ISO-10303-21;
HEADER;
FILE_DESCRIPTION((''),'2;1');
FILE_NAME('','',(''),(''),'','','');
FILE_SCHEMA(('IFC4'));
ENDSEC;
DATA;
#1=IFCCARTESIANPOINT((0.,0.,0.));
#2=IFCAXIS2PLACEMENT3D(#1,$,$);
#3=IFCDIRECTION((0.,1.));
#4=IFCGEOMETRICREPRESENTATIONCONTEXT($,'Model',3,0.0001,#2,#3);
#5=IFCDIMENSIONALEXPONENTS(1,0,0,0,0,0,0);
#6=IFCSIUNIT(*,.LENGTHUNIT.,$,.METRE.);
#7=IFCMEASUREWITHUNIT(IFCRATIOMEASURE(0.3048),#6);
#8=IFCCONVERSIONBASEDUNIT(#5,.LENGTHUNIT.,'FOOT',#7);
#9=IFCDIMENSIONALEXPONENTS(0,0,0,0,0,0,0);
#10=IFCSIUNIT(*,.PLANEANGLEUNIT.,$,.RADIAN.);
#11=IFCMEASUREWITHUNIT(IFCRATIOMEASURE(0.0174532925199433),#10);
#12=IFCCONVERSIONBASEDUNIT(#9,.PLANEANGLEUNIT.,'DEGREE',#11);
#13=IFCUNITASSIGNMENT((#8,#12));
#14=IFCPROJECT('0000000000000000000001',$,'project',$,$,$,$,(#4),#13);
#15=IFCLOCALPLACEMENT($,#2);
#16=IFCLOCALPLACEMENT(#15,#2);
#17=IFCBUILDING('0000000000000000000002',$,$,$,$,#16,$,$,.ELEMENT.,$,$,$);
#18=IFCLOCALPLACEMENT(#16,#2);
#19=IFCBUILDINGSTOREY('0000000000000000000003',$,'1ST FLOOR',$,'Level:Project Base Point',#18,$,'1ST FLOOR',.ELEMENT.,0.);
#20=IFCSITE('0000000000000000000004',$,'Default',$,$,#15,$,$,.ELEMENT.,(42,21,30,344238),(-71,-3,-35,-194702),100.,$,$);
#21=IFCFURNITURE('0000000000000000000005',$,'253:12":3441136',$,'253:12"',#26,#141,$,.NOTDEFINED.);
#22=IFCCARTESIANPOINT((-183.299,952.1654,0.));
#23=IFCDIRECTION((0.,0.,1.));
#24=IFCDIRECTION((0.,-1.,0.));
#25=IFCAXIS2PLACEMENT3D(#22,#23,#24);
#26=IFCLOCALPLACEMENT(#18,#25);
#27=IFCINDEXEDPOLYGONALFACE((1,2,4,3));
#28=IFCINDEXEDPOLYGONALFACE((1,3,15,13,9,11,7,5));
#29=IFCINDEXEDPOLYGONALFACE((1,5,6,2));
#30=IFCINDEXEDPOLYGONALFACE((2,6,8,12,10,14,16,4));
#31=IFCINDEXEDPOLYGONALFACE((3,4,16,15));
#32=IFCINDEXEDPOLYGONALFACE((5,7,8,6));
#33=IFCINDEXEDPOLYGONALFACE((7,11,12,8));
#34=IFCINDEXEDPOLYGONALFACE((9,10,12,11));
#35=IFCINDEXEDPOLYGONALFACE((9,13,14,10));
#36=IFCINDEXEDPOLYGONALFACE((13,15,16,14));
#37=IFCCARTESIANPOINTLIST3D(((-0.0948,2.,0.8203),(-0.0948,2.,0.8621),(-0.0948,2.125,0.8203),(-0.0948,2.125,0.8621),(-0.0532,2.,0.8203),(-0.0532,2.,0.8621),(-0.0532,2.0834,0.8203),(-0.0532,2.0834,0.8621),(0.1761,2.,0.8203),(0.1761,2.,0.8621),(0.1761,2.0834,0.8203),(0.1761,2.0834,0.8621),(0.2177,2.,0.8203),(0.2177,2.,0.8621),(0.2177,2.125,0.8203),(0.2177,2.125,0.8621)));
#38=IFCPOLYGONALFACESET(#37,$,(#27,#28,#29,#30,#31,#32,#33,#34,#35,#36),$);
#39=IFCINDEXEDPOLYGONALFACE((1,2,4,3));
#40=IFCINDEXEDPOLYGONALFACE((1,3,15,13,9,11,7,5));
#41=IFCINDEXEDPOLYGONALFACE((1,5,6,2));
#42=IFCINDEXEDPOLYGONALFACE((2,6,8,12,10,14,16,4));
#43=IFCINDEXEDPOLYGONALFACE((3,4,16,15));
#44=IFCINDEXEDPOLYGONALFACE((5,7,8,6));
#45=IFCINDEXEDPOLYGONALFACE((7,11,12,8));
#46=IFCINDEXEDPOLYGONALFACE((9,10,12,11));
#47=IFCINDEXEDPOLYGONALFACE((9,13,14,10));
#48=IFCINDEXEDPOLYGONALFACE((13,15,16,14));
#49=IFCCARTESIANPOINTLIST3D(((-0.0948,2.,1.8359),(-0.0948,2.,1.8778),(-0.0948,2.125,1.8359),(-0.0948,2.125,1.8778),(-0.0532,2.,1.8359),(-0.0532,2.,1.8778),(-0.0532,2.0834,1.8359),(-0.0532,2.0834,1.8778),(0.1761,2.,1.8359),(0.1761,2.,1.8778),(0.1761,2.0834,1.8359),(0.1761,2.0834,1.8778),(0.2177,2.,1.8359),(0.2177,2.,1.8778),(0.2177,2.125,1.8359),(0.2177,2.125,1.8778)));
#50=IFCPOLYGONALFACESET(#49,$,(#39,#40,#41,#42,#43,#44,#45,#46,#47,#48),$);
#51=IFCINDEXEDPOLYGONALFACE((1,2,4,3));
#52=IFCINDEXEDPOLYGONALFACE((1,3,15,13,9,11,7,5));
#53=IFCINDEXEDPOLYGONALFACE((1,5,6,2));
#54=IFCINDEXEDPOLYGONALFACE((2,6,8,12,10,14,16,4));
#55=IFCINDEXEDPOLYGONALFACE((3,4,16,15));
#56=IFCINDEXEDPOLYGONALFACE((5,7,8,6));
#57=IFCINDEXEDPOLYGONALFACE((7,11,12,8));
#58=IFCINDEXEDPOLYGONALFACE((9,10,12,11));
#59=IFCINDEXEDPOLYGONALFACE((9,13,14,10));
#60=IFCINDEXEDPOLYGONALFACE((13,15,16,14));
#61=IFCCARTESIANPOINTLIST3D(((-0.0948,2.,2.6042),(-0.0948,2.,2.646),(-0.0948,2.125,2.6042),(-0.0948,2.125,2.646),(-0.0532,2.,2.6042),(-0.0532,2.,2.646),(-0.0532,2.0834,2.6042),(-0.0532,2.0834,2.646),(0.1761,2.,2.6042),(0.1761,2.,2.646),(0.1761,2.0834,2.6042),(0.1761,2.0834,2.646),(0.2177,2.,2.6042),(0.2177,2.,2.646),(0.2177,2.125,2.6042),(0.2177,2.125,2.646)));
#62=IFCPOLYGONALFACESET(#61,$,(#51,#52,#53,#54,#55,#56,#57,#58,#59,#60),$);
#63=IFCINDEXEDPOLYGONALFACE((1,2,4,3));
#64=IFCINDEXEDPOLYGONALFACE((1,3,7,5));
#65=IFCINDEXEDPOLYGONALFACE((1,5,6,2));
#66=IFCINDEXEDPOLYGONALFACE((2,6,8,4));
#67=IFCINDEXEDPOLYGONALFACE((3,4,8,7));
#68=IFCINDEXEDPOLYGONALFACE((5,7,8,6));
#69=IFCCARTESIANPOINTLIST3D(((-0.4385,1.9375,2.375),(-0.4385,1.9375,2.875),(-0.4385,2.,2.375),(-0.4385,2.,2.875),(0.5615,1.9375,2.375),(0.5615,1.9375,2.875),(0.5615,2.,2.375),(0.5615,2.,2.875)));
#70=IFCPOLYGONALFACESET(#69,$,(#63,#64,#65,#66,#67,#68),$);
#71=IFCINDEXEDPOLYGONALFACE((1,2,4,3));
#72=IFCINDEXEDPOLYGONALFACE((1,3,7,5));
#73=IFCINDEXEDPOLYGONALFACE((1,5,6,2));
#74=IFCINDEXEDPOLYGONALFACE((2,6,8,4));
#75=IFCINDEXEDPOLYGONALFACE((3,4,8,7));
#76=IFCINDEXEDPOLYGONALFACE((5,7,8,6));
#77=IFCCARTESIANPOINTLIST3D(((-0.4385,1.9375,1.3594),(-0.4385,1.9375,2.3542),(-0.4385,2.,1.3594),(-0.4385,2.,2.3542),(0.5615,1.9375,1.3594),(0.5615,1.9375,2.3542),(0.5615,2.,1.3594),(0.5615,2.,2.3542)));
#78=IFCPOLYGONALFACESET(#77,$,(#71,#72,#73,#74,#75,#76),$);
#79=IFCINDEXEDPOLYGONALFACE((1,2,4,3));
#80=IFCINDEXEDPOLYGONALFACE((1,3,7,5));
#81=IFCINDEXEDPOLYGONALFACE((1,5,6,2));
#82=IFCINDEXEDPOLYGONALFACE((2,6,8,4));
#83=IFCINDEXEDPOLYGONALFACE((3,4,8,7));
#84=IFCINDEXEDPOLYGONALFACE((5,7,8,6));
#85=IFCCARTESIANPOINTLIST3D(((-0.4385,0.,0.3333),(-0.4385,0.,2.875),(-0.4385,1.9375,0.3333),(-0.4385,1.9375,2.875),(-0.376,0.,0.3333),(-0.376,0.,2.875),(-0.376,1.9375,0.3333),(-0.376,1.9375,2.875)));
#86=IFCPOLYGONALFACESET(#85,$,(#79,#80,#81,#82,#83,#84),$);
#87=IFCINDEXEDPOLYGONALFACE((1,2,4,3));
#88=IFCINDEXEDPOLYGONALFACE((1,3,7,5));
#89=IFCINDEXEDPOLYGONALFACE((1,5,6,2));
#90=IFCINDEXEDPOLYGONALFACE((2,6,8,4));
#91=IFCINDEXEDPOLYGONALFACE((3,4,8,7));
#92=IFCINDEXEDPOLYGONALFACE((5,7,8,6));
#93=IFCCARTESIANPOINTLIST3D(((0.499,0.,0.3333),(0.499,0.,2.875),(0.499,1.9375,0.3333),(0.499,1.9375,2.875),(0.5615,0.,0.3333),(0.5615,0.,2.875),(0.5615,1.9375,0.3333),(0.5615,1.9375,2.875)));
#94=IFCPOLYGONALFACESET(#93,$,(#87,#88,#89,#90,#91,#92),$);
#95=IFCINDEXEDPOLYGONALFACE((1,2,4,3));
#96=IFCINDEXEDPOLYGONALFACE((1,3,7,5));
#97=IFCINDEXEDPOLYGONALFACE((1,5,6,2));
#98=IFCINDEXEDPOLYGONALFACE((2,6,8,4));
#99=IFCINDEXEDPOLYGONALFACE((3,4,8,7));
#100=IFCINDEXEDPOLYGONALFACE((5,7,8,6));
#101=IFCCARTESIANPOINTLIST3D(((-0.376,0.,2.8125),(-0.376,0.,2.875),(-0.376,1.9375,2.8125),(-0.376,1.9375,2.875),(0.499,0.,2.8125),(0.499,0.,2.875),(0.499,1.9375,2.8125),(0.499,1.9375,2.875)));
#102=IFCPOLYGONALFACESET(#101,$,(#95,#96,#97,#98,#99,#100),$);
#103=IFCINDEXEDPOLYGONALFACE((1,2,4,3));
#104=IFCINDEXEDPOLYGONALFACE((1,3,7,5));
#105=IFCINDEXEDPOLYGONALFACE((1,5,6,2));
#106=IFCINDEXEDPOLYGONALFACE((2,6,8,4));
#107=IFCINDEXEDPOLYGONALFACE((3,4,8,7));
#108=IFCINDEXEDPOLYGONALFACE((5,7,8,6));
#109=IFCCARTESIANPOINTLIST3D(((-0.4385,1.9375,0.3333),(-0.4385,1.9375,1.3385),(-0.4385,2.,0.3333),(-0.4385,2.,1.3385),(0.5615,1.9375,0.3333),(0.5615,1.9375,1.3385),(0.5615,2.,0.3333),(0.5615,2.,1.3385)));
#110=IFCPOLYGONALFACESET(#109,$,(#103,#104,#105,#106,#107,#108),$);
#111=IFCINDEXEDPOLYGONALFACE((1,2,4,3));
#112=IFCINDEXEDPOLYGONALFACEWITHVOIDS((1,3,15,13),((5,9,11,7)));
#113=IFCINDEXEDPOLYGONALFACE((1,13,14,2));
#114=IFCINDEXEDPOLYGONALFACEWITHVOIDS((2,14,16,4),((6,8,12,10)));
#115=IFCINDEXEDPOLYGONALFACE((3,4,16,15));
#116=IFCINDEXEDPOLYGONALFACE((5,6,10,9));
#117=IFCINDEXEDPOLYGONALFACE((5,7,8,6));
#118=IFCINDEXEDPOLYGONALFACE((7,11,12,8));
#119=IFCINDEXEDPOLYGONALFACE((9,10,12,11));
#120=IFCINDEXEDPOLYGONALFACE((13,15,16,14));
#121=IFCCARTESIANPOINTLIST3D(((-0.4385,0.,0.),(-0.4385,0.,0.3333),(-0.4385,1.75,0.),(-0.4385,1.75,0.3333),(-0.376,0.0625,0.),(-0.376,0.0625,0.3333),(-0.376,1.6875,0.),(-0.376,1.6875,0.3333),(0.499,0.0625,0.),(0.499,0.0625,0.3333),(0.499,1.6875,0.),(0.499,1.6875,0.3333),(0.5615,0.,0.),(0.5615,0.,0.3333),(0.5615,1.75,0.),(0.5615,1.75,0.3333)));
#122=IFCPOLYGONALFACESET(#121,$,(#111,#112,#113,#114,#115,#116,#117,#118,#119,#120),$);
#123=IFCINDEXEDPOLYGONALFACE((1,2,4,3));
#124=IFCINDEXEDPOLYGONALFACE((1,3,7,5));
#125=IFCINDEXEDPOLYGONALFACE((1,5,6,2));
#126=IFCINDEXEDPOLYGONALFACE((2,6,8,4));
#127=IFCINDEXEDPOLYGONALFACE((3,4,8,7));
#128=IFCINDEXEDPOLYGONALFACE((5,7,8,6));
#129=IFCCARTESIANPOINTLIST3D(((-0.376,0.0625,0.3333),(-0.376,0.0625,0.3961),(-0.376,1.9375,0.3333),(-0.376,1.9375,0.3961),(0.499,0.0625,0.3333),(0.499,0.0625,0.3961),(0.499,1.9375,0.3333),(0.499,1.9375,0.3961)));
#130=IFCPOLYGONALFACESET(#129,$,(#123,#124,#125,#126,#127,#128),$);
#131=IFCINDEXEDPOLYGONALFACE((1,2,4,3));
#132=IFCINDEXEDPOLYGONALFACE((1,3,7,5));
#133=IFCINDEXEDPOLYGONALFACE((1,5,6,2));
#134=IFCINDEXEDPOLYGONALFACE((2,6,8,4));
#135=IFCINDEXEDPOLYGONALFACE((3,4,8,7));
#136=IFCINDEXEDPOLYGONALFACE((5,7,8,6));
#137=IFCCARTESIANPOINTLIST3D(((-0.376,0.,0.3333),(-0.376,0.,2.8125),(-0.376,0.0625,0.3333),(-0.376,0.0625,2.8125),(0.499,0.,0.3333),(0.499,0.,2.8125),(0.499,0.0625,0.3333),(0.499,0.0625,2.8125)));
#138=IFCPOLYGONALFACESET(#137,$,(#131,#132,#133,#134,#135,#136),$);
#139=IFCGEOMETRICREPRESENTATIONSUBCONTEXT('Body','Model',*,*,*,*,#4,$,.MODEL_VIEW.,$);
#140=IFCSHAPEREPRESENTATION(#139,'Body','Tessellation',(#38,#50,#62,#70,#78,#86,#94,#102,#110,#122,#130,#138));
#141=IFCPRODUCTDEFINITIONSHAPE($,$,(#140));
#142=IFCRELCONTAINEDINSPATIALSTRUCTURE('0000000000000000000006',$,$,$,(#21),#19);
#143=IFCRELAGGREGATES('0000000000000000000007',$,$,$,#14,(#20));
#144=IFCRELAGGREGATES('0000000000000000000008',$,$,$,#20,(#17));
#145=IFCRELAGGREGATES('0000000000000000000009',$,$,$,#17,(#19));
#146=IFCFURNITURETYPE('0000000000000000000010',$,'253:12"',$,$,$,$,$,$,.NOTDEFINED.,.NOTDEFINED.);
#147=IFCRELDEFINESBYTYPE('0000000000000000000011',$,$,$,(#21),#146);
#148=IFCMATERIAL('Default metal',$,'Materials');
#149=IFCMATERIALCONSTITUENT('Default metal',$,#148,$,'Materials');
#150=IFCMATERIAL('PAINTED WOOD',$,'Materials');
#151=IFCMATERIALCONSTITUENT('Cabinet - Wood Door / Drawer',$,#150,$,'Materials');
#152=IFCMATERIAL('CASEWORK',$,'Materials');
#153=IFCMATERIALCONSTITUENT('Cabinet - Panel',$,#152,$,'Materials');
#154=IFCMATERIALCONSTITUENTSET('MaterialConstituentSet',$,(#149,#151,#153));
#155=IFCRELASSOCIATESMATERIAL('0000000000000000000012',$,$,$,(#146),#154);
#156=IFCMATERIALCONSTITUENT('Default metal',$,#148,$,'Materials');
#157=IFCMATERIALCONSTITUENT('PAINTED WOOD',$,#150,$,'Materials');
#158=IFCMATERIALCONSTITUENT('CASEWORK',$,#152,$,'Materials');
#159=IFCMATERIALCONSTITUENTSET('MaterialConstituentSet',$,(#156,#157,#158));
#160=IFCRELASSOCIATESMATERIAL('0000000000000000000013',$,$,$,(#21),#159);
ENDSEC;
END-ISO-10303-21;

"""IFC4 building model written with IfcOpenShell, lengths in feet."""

from ifc_helpers import new_model, entity, si_unit, converted_unit, direction, frame, frame_2d, origin, origin_2d_with_axis, place, context, subcontext, project, spatial, polyline, rectangle, outline, extrude, source, transform, mapped, material, constituent, constituent_set, type_object, type_shapes, element, save


model = new_model("IFC4")

# Units and contexts
model_context = context("Model", 3, precision=0.0001, world=origin(), true_north=direction((0.0, 1.0)))
body_context = subcontext(model_context, "Body", "Model", "MODEL_VIEW")
ifc_project = project(units=[converted_unit("LENGTHUNIT", "FOOT", entity("IfcRatioMeasure", 0.3048), si_unit("LENGTHUNIT", "METRE"), dimensions=[1, 0, 0, 0, 0, 0, 0]), converted_unit("PLANEANGLEUNIT", "DEGREE", entity("IfcRatioMeasure", 0.0174532925199433), si_unit("PLANEANGLEUNIT", "RADIAN"), dimensions=[0, 0, 0, 0, 0, 0, 0])], contexts=[model_context])

# Site, building, storey
site_placement = place(None, origin())
site = spatial("IfcSite", under=ifc_project, at=site_placement, Name="Default", CompositionType="ELEMENT", RefLatitude=(42, 21, 30, 344238), RefLongitude=(-71, -3, -35, -194702), RefElevation=100.0)
building_placement = place(site_placement, origin())
building = spatial("IfcBuilding", under=site, at=building_placement, CompositionType="ELEMENT")
storey_placement = place(building_placement, origin())
storey = spatial("IfcBuildingStorey", under=building, at=storey_placement, Name="1ST FLOOR", ObjectType="Level:Project Base Point", LongName="1ST FLOOR", CompositionType="ELEMENT", Elevation=0.0)

# Shared definitions
ifc_material_1 = material(Name="CASEWORK", Category="Materials")

# Furniture
ifc_material_2 = material(Name="Default metal", Category="Materials")
ifc_material_3 = material(Name="PAINTED WOOD", Category="Materials")
ifc_constituent_1 = constituent(ifc_material_2, Name="Default metal", Category="Materials")
ifc_constituent_2 = constituent(ifc_material_3, Name="Cabinet - Wood Door / Drawer", Category="Materials")
ifc_constituent_3 = constituent(ifc_material_1, Name="Cabinet - Panel", Category="Materials")
ifc_constituent_set_1 = constituent_set(constituents=[ifc_constituent_1, ifc_constituent_2, ifc_constituent_3], Name="MaterialConstituentSet")
furniture_type_1 = type_object("IfcFurnitureType", Name="253:12\"", AssemblyPlace="NOTDEFINED", PredefinedType="NOTDEFINED", material=ifc_constituent_set_1)
shared_shape_1 = source(origin(), body_context, "Body", "SweptSolid", [
    extrude(outline(polyline([(-0.1562, -0.0521), (-0.1146, -0.0521), (-0.1146, 0.0313), (0.1146, 0.0313), (0.1146, -0.0521), (0.1562, -0.0521), (0.1562, 0.0729), (-0.1562, 0.0729), (-0.1562, -0.0521)])), frame((0.0615, 2.0521, 0.8203)), (0.0, 0.0, 1.0), 0.0418),
    extrude(outline(polyline([(-0.1562, -0.0521), (-0.1146, -0.0521), (-0.1146, 0.0313), (0.1146, 0.0313), (0.1146, -0.0521), (0.1562, -0.0521), (0.1562, 0.0729), (-0.1562, 0.0729), (-0.1562, -0.0521)])), frame((0.0615, 2.0521, 1.8359)), (0.0, 0.0, 1.0), 0.0418),
    extrude(outline(polyline([(-0.1562, -0.0521), (-0.1146, -0.0521), (-0.1146, 0.0313), (0.1146, 0.0313), (0.1146, -0.0521), (0.1562, -0.0521), (0.1562, 0.0729), (-0.1562, 0.0729), (-0.1562, -0.0521)])), frame((0.0615, 2.0521, 2.6042)), (0.0, 0.0, 1.0), 0.0418),
    extrude(rectangle(XDim=1.0, YDim=0.0625, at=frame_2d((0.0, 0.0), x_axis=(1.0, 0.0))), frame((0.0615, 1.9688, 2.375), z_axis=(0.0, 0.0, 1.0), x_axis=(-1.0, 0.0, 0.0)), (0.0, 0.0, 1.0), 0.5),
    extrude(rectangle(XDim=1.0, YDim=0.0625, at=frame_2d((0.0, 0.0), x_axis=(1.0, 0.0))), frame((0.0615, 1.9688, 1.3594), z_axis=(0.0, 0.0, 1.0), x_axis=(-1.0, 0.0, 0.0)), (0.0, 0.0, 1.0), 0.9948),
    extrude(rectangle(XDim=1.9375, YDim=0.0625, at=frame_2d((0.0, 0.0), x_axis=(1.0, 0.0))), frame((-0.4073, 0.9687, 0.3333), z_axis=(0.0, 0.0, 1.0), x_axis=(0.0, -1.0, 0.0)), (0.0, 0.0, 1.0), 2.5417),
    extrude(rectangle(XDim=1.9375, YDim=0.0625, at=frame_2d((0.0, 0.0), x_axis=(1.0, 0.0))), frame((0.5302, 0.9687, 0.3333), z_axis=(0.0, 0.0, 1.0), x_axis=(0.0, -1.0, 0.0)), (0.0, 0.0, 1.0), 2.5417),
    extrude(rectangle(XDim=1.9375, YDim=0.875, at=origin_2d_with_axis()), frame((0.0615, 0.9688, 2.8125), z_axis=(0.0, 0.0, 1.0), x_axis=(0.0, 1.0, 0.0)), (0.0, 0.0, 1.0), 0.0625),
    extrude(rectangle(XDim=1.0, YDim=0.0625, at=frame_2d((0.0, 0.0), x_axis=(1.0, 0.0))), frame((0.0615, 1.9688, 0.3333), z_axis=(0.0, 0.0, 1.0), x_axis=(-1.0, 0.0, 0.0)), (0.0, 0.0, 1.0), 1.0052),
    extrude(outline(polyline([(-0.875, -0.5), (0.875, -0.5), (0.875, 0.5), (-0.875, 0.5), (-0.875, -0.5)]), holes=[polyline([(-0.8125, -0.4375), (-0.8125, 0.4375), (0.8125, 0.4375), (0.8125, -0.4375), (-0.8125, -0.4375)])]), frame((0.0615, 0.875, 0.0), z_axis=(0.0, 0.0, 1.0), x_axis=(0.0, -1.0, 0.0)), (0.0, 0.0, 1.0), 0.3333),
    extrude(rectangle(XDim=1.875, YDim=0.875, at=origin_2d_with_axis()), frame((0.0615, 1.0, 0.3333), z_axis=(0.0, 0.0, 1.0), x_axis=(0.0, 1.0, 0.0)), (0.0, 0.0, 1.0), 0.0627),
    extrude(rectangle(XDim=0.875, YDim=0.0625, at=origin_2d_with_axis()), frame((0.0615, 0.0312, 0.3333), z_axis=(0.0, 0.0, 1.0), x_axis=(-1.0, 0.0, 0.0)), (0.0, 0.0, 1.0), 2.4792),
])
type_shapes(furniture_type_1, [shared_shape_1])
ifc_constituent_4 = constituent(ifc_material_2, Name="Default metal", Category="Materials")
ifc_constituent_5 = constituent(ifc_material_3, Name="PAINTED WOOD", Category="Materials")
ifc_constituent_6 = constituent(ifc_material_1, Name="CASEWORK", Category="Materials")
ifc_constituent_set_2 = constituent_set(constituents=[ifc_constituent_4, ifc_constituent_5, ifc_constituent_6], Name="MaterialConstituentSet")
furniture_1_placement = place(storey_placement, frame((-183.299, 952.1654, 0.0), z_axis=(0.0, 0.0, 1.0), x_axis=(0.0, -1.0, 0.0)))
element("IfcFurniture", 1, at=furniture_1_placement, inside=storey, type_object=furniture_type_1, material=ifc_constituent_set_2, Name="253:12\":3441136", ObjectType="253:12\"", PredefinedType="NOTDEFINED", context=body_context, shape_type="MappedRepresentation", body=[
    mapped(shared_shape_1, transform((0.0, 0.0, 0.0), scale=1.0)),
])

save(model, "model.ifc")
